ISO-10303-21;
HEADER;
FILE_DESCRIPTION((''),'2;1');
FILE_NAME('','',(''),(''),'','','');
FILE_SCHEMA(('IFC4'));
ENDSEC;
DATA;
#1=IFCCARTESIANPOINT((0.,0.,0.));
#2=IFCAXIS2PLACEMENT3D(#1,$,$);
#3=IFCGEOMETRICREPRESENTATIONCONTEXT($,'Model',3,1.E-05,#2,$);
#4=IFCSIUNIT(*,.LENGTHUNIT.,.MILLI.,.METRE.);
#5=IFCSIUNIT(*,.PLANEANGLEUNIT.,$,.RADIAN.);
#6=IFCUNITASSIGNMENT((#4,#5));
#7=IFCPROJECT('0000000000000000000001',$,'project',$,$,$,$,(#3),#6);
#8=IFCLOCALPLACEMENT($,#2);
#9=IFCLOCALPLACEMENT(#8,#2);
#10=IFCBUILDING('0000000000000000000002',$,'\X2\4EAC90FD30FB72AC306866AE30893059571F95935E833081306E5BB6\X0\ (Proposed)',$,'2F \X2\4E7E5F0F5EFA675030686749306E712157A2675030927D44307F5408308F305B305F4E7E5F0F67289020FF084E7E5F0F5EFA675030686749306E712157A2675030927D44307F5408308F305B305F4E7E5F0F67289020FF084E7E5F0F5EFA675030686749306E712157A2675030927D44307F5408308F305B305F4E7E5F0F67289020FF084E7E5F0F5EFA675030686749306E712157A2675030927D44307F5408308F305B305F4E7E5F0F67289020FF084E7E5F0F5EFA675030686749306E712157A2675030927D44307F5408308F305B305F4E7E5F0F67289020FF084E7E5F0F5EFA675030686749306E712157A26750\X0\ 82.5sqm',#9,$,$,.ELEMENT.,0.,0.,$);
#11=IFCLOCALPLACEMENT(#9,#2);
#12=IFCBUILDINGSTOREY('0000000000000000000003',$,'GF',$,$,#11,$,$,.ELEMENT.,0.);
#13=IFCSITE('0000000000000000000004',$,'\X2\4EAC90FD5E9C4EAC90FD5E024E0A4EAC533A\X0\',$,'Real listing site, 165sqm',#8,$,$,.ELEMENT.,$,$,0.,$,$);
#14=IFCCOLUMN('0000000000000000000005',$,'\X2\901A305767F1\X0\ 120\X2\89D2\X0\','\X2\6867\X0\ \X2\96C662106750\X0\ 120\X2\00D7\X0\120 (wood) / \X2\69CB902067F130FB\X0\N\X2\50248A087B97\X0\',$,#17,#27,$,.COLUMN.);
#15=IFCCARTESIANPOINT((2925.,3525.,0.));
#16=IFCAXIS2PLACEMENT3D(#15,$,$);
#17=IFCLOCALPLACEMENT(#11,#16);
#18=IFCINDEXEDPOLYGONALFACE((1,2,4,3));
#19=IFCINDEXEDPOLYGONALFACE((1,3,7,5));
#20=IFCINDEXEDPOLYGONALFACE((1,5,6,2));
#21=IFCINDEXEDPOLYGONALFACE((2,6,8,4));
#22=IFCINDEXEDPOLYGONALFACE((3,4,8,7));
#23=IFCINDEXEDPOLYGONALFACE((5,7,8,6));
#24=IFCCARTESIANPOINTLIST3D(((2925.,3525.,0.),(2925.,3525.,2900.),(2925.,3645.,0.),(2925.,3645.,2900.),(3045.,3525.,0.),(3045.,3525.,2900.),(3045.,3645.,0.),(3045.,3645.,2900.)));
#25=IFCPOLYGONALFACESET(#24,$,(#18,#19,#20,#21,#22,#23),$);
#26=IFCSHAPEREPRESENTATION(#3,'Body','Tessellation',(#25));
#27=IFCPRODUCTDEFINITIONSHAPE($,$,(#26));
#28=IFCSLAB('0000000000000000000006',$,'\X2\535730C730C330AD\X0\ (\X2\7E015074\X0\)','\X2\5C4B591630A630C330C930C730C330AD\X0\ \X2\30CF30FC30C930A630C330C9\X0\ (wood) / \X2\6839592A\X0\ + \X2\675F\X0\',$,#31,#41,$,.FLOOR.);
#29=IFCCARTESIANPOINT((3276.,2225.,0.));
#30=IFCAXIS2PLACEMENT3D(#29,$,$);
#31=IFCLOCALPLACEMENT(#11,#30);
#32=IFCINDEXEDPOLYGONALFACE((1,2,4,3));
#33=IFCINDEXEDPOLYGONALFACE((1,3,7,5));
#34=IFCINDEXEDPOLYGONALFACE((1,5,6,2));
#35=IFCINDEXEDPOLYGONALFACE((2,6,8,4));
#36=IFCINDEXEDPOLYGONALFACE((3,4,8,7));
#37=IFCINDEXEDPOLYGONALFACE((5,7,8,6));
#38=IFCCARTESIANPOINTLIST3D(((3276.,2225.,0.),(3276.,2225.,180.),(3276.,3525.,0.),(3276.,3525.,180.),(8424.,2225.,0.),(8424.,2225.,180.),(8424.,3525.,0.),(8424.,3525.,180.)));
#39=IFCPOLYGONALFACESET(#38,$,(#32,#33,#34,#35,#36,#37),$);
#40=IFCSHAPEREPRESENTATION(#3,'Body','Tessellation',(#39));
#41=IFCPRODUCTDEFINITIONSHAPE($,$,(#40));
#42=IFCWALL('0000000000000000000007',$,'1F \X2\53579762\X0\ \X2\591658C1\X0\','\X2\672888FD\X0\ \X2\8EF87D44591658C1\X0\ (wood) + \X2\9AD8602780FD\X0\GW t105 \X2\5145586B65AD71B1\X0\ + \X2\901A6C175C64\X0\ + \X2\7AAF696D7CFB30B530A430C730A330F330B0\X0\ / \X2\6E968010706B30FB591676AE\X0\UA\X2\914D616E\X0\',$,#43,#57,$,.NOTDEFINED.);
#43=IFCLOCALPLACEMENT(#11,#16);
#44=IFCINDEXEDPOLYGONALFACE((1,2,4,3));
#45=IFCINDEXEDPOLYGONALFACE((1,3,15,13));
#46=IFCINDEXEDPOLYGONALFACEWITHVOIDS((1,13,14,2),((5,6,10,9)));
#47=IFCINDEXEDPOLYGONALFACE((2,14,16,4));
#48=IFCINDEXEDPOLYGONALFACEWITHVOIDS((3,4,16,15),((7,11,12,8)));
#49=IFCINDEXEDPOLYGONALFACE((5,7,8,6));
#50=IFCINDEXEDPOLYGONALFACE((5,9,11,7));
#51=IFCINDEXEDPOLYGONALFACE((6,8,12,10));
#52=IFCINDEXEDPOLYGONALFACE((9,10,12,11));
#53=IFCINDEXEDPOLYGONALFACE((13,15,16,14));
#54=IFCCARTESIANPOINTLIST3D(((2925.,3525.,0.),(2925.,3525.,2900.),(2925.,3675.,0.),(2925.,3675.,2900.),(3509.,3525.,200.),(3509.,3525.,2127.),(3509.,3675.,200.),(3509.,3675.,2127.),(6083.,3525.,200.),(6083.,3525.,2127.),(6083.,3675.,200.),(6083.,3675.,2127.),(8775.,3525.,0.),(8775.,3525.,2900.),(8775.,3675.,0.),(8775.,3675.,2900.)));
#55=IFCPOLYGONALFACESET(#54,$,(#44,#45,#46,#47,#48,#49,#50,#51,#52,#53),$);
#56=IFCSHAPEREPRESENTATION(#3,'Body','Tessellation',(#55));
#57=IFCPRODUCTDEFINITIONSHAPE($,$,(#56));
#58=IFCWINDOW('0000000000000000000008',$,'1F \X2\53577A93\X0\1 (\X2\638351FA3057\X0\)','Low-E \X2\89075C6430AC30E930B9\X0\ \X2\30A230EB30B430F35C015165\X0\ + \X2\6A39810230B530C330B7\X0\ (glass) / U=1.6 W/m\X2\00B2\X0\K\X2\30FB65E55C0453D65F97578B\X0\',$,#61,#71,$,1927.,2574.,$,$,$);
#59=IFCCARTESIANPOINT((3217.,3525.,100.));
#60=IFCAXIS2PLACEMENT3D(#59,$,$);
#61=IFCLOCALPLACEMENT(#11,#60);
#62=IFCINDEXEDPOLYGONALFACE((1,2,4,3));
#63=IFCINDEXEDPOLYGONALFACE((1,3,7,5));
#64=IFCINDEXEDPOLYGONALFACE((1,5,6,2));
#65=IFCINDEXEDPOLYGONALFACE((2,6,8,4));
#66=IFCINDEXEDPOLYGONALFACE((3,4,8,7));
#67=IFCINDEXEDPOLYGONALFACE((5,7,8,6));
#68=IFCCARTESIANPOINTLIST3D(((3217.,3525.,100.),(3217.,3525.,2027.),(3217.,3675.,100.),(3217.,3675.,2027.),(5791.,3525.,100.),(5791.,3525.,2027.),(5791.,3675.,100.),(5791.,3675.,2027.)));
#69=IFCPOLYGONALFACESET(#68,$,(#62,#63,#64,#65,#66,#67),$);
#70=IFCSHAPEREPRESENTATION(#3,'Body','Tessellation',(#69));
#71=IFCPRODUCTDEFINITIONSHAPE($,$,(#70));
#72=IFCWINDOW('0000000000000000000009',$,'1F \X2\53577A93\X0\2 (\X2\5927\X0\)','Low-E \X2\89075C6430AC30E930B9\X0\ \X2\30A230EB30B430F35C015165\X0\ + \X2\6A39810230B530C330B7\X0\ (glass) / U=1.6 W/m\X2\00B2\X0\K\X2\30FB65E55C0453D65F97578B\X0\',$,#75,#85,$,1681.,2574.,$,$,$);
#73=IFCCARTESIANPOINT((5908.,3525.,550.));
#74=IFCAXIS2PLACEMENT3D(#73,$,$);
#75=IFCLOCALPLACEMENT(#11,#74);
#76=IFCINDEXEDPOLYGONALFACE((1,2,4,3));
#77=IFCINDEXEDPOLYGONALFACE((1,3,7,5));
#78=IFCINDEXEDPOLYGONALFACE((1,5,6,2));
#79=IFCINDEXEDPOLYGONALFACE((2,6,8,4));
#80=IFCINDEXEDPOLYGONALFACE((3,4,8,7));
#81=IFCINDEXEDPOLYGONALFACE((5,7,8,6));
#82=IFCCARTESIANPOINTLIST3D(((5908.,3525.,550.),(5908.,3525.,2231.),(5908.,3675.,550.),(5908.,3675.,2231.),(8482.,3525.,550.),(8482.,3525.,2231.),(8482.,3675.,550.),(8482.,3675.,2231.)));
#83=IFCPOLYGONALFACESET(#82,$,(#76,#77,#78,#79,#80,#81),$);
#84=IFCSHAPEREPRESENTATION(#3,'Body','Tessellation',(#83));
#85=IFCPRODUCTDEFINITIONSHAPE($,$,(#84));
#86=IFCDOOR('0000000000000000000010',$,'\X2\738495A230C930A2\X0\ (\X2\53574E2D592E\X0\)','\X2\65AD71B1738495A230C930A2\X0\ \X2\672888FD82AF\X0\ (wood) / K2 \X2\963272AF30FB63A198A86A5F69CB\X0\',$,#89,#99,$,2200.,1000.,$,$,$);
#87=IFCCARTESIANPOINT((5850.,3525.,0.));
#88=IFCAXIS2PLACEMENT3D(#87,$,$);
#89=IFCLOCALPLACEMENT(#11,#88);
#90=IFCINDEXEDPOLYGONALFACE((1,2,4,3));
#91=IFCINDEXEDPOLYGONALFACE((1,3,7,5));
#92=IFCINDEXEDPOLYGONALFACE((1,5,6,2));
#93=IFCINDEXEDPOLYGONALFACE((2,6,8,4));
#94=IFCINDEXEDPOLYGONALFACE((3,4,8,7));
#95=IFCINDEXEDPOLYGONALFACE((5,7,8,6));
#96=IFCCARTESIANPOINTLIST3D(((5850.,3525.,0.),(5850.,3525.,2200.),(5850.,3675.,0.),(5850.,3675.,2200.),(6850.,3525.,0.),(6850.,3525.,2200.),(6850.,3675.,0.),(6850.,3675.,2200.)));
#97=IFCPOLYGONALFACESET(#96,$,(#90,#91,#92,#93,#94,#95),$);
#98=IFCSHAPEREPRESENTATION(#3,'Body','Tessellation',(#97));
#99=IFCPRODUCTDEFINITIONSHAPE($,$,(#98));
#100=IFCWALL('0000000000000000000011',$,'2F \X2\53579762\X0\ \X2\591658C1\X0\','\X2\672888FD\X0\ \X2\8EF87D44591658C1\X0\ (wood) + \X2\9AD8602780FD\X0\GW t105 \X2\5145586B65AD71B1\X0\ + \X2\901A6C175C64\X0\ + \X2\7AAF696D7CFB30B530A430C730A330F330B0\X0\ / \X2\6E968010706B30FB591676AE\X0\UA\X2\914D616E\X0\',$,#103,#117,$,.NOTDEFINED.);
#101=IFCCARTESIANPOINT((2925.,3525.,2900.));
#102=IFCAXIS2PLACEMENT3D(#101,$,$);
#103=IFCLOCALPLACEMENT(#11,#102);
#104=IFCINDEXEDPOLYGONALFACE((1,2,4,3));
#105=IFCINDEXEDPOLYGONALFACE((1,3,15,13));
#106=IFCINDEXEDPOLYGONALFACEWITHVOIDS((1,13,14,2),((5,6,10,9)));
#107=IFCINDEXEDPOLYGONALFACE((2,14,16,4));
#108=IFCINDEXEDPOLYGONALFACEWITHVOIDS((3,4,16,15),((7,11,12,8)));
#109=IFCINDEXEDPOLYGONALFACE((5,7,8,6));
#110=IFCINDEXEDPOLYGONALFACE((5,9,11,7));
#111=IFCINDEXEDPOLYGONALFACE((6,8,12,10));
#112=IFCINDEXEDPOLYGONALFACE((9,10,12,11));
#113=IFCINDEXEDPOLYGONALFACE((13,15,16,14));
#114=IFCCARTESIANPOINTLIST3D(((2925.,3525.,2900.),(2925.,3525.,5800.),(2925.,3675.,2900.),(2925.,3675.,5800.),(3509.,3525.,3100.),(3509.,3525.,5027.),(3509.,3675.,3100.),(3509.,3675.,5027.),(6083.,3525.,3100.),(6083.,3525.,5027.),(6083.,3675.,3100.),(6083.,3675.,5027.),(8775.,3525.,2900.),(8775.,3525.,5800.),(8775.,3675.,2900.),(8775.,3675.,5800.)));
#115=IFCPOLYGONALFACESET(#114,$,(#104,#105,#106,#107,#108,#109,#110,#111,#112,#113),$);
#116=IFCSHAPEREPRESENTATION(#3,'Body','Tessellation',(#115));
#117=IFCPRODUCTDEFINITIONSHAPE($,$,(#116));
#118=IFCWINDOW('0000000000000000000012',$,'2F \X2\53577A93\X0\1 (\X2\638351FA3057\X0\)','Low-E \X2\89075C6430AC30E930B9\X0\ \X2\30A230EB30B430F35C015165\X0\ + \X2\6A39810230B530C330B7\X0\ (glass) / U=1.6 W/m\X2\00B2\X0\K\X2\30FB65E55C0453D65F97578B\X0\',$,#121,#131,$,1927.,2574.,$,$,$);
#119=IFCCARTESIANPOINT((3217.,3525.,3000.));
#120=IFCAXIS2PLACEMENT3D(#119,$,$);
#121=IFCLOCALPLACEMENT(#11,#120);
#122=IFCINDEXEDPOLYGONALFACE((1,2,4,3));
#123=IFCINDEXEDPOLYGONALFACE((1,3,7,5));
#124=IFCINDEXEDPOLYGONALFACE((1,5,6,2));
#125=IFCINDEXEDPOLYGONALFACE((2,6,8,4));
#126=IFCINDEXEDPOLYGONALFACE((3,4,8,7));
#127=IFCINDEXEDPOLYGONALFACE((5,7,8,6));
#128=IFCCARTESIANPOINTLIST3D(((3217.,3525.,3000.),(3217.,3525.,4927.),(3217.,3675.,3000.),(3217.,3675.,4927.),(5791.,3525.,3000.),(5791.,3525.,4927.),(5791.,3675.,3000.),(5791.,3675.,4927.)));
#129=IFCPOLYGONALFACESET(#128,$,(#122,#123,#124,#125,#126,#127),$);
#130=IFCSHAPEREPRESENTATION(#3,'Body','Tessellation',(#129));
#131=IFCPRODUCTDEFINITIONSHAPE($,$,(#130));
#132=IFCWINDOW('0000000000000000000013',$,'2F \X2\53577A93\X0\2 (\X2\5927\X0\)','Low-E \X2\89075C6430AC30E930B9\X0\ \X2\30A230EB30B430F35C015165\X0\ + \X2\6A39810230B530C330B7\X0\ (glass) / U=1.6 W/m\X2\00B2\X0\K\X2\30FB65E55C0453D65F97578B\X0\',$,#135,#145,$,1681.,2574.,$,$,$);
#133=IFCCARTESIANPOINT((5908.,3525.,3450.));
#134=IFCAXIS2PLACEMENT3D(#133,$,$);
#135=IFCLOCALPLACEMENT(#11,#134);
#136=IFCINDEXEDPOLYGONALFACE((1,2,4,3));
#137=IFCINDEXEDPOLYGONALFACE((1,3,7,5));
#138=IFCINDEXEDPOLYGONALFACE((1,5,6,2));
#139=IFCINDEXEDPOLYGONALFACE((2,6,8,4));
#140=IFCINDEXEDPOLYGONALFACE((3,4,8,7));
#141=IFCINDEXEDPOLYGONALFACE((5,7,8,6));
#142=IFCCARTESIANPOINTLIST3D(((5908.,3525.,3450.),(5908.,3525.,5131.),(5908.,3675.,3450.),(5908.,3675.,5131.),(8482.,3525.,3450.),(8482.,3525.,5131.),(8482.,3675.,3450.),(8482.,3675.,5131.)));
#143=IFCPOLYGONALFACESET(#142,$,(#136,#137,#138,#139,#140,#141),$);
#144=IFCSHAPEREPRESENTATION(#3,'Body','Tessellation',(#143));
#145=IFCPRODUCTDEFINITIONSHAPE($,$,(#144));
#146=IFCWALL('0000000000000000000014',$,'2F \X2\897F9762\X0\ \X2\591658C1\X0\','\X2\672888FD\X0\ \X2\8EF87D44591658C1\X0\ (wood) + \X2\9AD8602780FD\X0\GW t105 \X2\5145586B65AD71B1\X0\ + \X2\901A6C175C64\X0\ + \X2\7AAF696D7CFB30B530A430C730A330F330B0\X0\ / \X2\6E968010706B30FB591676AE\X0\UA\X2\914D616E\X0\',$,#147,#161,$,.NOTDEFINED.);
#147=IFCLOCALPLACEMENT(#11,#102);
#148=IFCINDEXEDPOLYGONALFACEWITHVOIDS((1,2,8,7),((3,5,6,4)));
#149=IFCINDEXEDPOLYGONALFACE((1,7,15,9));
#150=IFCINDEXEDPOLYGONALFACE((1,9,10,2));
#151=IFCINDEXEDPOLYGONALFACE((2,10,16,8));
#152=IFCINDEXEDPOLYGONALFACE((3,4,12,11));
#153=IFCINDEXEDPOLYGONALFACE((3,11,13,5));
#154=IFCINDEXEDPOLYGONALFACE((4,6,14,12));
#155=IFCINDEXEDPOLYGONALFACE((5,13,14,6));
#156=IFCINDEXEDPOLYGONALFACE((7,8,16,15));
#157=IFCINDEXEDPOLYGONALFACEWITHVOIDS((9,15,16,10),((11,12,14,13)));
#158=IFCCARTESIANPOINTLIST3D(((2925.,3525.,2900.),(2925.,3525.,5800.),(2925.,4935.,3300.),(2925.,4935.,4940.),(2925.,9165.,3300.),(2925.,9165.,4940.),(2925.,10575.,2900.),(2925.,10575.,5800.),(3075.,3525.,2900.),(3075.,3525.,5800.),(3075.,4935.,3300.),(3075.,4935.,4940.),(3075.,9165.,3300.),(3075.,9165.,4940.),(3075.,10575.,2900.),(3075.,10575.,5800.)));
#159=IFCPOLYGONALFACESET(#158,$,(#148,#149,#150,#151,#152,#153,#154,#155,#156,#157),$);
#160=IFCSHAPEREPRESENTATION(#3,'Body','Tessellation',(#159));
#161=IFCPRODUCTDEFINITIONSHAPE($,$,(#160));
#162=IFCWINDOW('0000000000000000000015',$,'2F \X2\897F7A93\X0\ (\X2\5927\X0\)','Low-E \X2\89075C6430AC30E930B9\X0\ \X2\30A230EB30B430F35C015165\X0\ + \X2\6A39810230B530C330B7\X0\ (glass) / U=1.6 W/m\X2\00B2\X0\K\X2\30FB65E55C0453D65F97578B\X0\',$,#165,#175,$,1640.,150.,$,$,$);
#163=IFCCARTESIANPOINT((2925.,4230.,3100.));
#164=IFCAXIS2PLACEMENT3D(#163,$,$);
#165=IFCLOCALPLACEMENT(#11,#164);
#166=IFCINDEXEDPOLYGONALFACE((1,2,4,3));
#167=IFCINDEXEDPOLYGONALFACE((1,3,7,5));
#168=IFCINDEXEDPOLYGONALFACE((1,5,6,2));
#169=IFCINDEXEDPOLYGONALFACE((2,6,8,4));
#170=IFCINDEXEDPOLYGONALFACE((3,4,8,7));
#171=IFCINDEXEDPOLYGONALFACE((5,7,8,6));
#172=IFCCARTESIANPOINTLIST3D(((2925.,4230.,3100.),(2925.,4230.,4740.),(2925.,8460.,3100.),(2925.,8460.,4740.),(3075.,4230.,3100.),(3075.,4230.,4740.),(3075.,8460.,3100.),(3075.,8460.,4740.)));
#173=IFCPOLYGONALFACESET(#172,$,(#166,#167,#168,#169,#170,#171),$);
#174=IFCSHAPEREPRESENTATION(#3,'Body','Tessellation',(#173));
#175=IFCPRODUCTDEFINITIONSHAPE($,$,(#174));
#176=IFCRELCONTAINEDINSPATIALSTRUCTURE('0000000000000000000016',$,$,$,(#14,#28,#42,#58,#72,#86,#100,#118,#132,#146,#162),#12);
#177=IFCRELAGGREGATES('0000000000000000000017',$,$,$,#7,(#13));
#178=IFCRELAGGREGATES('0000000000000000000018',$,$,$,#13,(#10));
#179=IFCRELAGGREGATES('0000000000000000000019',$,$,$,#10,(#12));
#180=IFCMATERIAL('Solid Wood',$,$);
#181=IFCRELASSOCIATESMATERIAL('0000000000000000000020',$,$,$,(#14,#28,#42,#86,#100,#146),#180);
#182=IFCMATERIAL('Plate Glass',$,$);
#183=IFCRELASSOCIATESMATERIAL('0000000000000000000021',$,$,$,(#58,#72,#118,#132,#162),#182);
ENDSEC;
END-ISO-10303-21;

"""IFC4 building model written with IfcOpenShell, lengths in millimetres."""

from ifc_helpers import new_model, si_unit, frame, frame_2d, origin, place, context, project, spatial, rectangle, extrude, material, element, fill, save


model = new_model("IFC4")

# Units and contexts
model_context = context("Model", 3, precision=1e-05, world=origin())
ifc_project = project(units=[si_unit("LENGTHUNIT", "METRE", prefix="MILLI"), si_unit("PLANEANGLEUNIT", "RADIAN")], contexts=[model_context])

# Site, building, storey
site_placement = place(None, origin())
site = spatial("IfcSite", under=ifc_project, at=site_placement, Name="京都府京都市上京区", ObjectType="Real listing site, 165sqm", CompositionType="ELEMENT", RefElevation=0.0)
building_placement = place(site_placement, origin())
building = spatial("IfcBuilding", under=site, at=building_placement, Name="京都・犬と暮らす土間広めの家 (Proposed)", ObjectType="2F 乾式建材と杉の無垢材を組み合わせた乾式木造（乾式建材と杉の無垢材を組み合わせた乾式木造（乾式建材と杉の無垢材を組み合わせた乾式木造（乾式建材と杉の無垢材を組み合わせた乾式木造（乾式建材と杉の無垢材を組み合わせた乾式木造（乾式建材と杉の無垢材 82.5sqm", CompositionType="ELEMENT", ElevationOfRefHeight=0.0, ElevationOfTerrain=0.0)
storey_placement = place(building_placement, origin())
storey = spatial("IfcBuildingStorey", under=building, at=storey_placement, Name="GF", CompositionType="ELEMENT", Elevation=0.0)

# Column
ifc_material_1 = material(Name="Solid Wood")
column_placement = place(storey_placement, frame((2925.0, 3525.0, 0.0)))
element("IfcColumn", 1, at=column_placement, inside=storey, material=ifc_material_1, Name="通し柱 120角", Description="桧 集成材 120×120 (wood) / 構造柱・N値計算", PredefinedType="COLUMN", context=model_context, shape_type="SweptSolid", body=[
    extrude(rectangle(XDim=120.0, YDim=120.0, at=frame_2d((60.0, 60.0))), frame((2925.0, 3525.0, 0.0)), (0.0, 0.0, 1.0), 2900.0),
])

# Slab
slab_1_placement = place(storey_placement, frame((3276.0, 2225.0, 0.0)))
element("IfcSlab", 2, at=slab_1_placement, inside=storey, material=ifc_material_1, Name="南デッキ (縁側)", Description="屋外ウッドデッキ ハードウッド (wood) / 根太 + 束", PredefinedType="FLOOR", context=model_context, shape_type="SweptSolid", body=[
    extrude(rectangle(XDim=5148.0, YDim=1300.0, at=frame_2d((2574.0, 650.0))), frame((3276.0, 2225.0, 0.0)), (0.0, 0.0, 1.0), 180.0),
])

# Wall, openings, windows, door
wall_1_placement = place(storey_placement, frame((2925.0, 3525.0, 0.0)))
wall_1 = element("IfcWall", 3, at=wall_1_placement, inside=storey, material=ifc_material_1, Name="1F 南面 外壁", Description="木製 軸組外壁 (wood) + 高性能GW t105 充填断熱 + 通気層 + 窯業系サイディング / 準耐火・外皮UA配慮", PredefinedType="NOTDEFINED", context=model_context, shape_type="SweptSolid", body=[
    extrude(rectangle(XDim=5850.0, YDim=150.0, at=frame_2d((2925.0, 75.0))), frame((2925.0, 3525.0, 0.0)), (0.0, 0.0, 1.0), 2900.0),
])
opening_1_placement = place(storey_placement, frame((3217.0, 3525.0, 100.0)))
opening_1 = element("IfcOpeningElement", 4, at=opening_1_placement, cuts=wall_1, PredefinedType="NOTDEFINED", context=model_context, shape_type="SweptSolid", body=[
    extrude(rectangle(XDim=2574.0, YDim=150.0, at=frame_2d((1287.0, 75.0))), frame((3217.0, 3525.0, 100.0)), (0.0, 0.0, 1.0), 1927.0),
])
opening_2_placement = place(storey_placement, frame((5908.0, 3525.0, 550.0)))
opening_2 = element("IfcOpeningElement", 5, at=opening_2_placement, cuts=wall_1, PredefinedType="NOTDEFINED", context=model_context, shape_type="SweptSolid", body=[
    extrude(rectangle(XDim=2574.0, YDim=150.0, at=frame_2d((1287.0, 75.0))), frame((5908.0, 3525.0, 550.0)), (0.0, 0.0, 1.0), 1681.0),
])
opening_3_placement = place(storey_placement, frame((5850.0, 3525.0, 0.0)))
opening_3 = element("IfcOpeningElement", 6, at=opening_3_placement, cuts=wall_1, PredefinedType="NOTDEFINED", context=model_context, shape_type="SweptSolid", body=[
    extrude(rectangle(XDim=1000.0, YDim=150.0, at=frame_2d((500.0, 75.0))), frame((5850.0, 3525.0, 0.0)), (0.0, 0.0, 1.0), 2200.0),
])
ifc_material_2 = material(Name="Plate Glass")
window_1_placement = place(storey_placement, frame((3217.0, 3525.0, 100.0)))
window_1 = element("IfcWindow", 7, at=window_1_placement, inside=storey, material=ifc_material_2, Name="1F 南窓1 (掃出し)", Description="Low-E 複層ガラス アルゴン封入 + 樹脂サッシ (glass) / U=1.6 W/m²K・日射取得型", OverallHeight=1927.0, OverallWidth=2574.0, context=model_context, shape_type="SweptSolid", body=[
    extrude(rectangle(XDim=2574.0, YDim=150.0, at=frame_2d((1287.0, 75.0))), frame((3217.0, 3525.0, 100.0)), (0.0, 0.0, 1.0), 1927.0),
])
fill(opening_1, window_1)
window_2_placement = place(storey_placement, frame((5908.0, 3525.0, 550.0)))
window_2 = element("IfcWindow", 8, at=window_2_placement, inside=storey, material=ifc_material_2, Name="1F 南窓2 (大)", Description="Low-E 複層ガラス アルゴン封入 + 樹脂サッシ (glass) / U=1.6 W/m²K・日射取得型", OverallHeight=1681.0, OverallWidth=2574.0, context=model_context, shape_type="SweptSolid", body=[
    extrude(rectangle(XDim=2574.0, YDim=150.0, at=frame_2d((1287.0, 75.0))), frame((5908.0, 3525.0, 550.0)), (0.0, 0.0, 1.0), 1681.0),
])
fill(opening_2, window_2)
door_placement = place(storey_placement, frame((5850.0, 3525.0, 0.0)))
door = element("IfcDoor", 9, at=door_placement, inside=storey, material=ifc_material_1, Name="玄関ドア (南中央)", Description="断熱玄関ドア 木製芯 (wood) / K2 防犯・採風機構", OverallHeight=2200.0, OverallWidth=1000.0, context=model_context, shape_type="SweptSolid", body=[
    extrude(rectangle(XDim=1000.0, YDim=150.0, at=frame_2d((500.0, 75.0))), frame((5850.0, 3525.0, 0.0)), (0.0, 0.0, 1.0), 2200.0),
])
fill(opening_3, door)

# Wall, openings, windows
wall_2_placement = place(storey_placement, frame((2925.0, 3525.0, 2900.0)))
wall_2 = element("IfcWall", 10, at=wall_2_placement, inside=storey, material=ifc_material_1, Name="2F 南面 外壁", Description="木製 軸組外壁 (wood) + 高性能GW t105 充填断熱 + 通気層 + 窯業系サイディング / 準耐火・外皮UA配慮", PredefinedType="NOTDEFINED", context=model_context, shape_type="SweptSolid", body=[
    extrude(rectangle(XDim=5850.0, YDim=150.0, at=frame_2d((2925.0, 75.0))), frame((2925.0, 3525.0, 2900.0)), (0.0, 0.0, 1.0), 2900.0),
])
opening_4_placement = place(storey_placement, frame((3217.0, 3525.0, 3000.0)))
opening_4 = element("IfcOpeningElement", 11, at=opening_4_placement, cuts=wall_2, PredefinedType="NOTDEFINED", context=model_context, shape_type="SweptSolid", body=[
    extrude(rectangle(XDim=2574.0, YDim=150.0, at=frame_2d((1287.0, 75.0))), frame((3217.0, 3525.0, 3000.0)), (0.0, 0.0, 1.0), 1927.0),
])
opening_5_placement = place(storey_placement, frame((5908.0, 3525.0, 3450.0)))
opening_5 = element("IfcOpeningElement", 12, at=opening_5_placement, cuts=wall_2, PredefinedType="NOTDEFINED", context=model_context, shape_type="SweptSolid", body=[
    extrude(rectangle(XDim=2574.0, YDim=150.0, at=frame_2d((1287.0, 75.0))), frame((5908.0, 3525.0, 3450.0)), (0.0, 0.0, 1.0), 1681.0),
])
window_3_placement = place(storey_placement, frame((3217.0, 3525.0, 3000.0)))
window_3 = element("IfcWindow", 13, at=window_3_placement, inside=storey, material=ifc_material_2, Name="2F 南窓1 (掃出し)", Description="Low-E 複層ガラス アルゴン封入 + 樹脂サッシ (glass) / U=1.6 W/m²K・日射取得型", OverallHeight=1927.0, OverallWidth=2574.0, context=model_context, shape_type="SweptSolid", body=[
    extrude(rectangle(XDim=2574.0, YDim=150.0, at=frame_2d((1287.0, 75.0))), frame((3217.0, 3525.0, 3000.0)), (0.0, 0.0, 1.0), 1927.0),
])
fill(opening_4, window_3)
window_4_placement = place(storey_placement, frame((5908.0, 3525.0, 3450.0)))
window_4 = element("IfcWindow", 14, at=window_4_placement, inside=storey, material=ifc_material_2, Name="2F 南窓2 (大)", Description="Low-E 複層ガラス アルゴン封入 + 樹脂サッシ (glass) / U=1.6 W/m²K・日射取得型", OverallHeight=1681.0, OverallWidth=2574.0, context=model_context, shape_type="SweptSolid", body=[
    extrude(rectangle(XDim=2574.0, YDim=150.0, at=frame_2d((1287.0, 75.0))), frame((5908.0, 3525.0, 3450.0)), (0.0, 0.0, 1.0), 1681.0),
])
fill(opening_5, window_4)

# Wall, opening, window
wall_3_placement = place(storey_placement, frame((2925.0, 3525.0, 2900.0)))
wall_3 = element("IfcWall", 15, at=wall_3_placement, inside=storey, material=ifc_material_1, Name="2F 西面 外壁", Description="木製 軸組外壁 (wood) + 高性能GW t105 充填断熱 + 通気層 + 窯業系サイディング / 準耐火・外皮UA配慮", PredefinedType="NOTDEFINED", context=model_context, shape_type="SweptSolid", body=[
    extrude(rectangle(XDim=150.0, YDim=7050.0, at=frame_2d((75.0, 3525.0))), frame((2925.0, 3525.0, 2900.0)), (0.0, 0.0, 1.0), 2900.0),
])
opening_6_placement = place(storey_placement, frame((2925.0, 4230.0, 3100.0)))
opening_6 = element("IfcOpeningElement", 16, at=opening_6_placement, cuts=wall_3, PredefinedType="NOTDEFINED", context=model_context, shape_type="SweptSolid", body=[
    extrude(rectangle(XDim=150.0, YDim=4230.0, at=frame_2d((75.0, 2115.0))), frame((2925.0, 4230.0, 3100.0)), (0.0, 0.0, 1.0), 1640.0),
])
window_5_placement = place(storey_placement, frame((2925.0, 4230.0, 3100.0)))
window_5 = element("IfcWindow", 17, at=window_5_placement, inside=storey, material=ifc_material_2, Name="2F 西窓 (大)", Description="Low-E 複層ガラス アルゴン封入 + 樹脂サッシ (glass) / U=1.6 W/m²K・日射取得型", OverallHeight=1640.0, OverallWidth=150.0, context=model_context, shape_type="SweptSolid", body=[
    extrude(rectangle(XDim=150.0, YDim=4230.0, at=frame_2d((75.0, 2115.0))), frame((2925.0, 4230.0, 3100.0)), (0.0, 0.0, 1.0), 1640.0),
])
fill(opening_6, window_5)

save(model, "model.ifc")
